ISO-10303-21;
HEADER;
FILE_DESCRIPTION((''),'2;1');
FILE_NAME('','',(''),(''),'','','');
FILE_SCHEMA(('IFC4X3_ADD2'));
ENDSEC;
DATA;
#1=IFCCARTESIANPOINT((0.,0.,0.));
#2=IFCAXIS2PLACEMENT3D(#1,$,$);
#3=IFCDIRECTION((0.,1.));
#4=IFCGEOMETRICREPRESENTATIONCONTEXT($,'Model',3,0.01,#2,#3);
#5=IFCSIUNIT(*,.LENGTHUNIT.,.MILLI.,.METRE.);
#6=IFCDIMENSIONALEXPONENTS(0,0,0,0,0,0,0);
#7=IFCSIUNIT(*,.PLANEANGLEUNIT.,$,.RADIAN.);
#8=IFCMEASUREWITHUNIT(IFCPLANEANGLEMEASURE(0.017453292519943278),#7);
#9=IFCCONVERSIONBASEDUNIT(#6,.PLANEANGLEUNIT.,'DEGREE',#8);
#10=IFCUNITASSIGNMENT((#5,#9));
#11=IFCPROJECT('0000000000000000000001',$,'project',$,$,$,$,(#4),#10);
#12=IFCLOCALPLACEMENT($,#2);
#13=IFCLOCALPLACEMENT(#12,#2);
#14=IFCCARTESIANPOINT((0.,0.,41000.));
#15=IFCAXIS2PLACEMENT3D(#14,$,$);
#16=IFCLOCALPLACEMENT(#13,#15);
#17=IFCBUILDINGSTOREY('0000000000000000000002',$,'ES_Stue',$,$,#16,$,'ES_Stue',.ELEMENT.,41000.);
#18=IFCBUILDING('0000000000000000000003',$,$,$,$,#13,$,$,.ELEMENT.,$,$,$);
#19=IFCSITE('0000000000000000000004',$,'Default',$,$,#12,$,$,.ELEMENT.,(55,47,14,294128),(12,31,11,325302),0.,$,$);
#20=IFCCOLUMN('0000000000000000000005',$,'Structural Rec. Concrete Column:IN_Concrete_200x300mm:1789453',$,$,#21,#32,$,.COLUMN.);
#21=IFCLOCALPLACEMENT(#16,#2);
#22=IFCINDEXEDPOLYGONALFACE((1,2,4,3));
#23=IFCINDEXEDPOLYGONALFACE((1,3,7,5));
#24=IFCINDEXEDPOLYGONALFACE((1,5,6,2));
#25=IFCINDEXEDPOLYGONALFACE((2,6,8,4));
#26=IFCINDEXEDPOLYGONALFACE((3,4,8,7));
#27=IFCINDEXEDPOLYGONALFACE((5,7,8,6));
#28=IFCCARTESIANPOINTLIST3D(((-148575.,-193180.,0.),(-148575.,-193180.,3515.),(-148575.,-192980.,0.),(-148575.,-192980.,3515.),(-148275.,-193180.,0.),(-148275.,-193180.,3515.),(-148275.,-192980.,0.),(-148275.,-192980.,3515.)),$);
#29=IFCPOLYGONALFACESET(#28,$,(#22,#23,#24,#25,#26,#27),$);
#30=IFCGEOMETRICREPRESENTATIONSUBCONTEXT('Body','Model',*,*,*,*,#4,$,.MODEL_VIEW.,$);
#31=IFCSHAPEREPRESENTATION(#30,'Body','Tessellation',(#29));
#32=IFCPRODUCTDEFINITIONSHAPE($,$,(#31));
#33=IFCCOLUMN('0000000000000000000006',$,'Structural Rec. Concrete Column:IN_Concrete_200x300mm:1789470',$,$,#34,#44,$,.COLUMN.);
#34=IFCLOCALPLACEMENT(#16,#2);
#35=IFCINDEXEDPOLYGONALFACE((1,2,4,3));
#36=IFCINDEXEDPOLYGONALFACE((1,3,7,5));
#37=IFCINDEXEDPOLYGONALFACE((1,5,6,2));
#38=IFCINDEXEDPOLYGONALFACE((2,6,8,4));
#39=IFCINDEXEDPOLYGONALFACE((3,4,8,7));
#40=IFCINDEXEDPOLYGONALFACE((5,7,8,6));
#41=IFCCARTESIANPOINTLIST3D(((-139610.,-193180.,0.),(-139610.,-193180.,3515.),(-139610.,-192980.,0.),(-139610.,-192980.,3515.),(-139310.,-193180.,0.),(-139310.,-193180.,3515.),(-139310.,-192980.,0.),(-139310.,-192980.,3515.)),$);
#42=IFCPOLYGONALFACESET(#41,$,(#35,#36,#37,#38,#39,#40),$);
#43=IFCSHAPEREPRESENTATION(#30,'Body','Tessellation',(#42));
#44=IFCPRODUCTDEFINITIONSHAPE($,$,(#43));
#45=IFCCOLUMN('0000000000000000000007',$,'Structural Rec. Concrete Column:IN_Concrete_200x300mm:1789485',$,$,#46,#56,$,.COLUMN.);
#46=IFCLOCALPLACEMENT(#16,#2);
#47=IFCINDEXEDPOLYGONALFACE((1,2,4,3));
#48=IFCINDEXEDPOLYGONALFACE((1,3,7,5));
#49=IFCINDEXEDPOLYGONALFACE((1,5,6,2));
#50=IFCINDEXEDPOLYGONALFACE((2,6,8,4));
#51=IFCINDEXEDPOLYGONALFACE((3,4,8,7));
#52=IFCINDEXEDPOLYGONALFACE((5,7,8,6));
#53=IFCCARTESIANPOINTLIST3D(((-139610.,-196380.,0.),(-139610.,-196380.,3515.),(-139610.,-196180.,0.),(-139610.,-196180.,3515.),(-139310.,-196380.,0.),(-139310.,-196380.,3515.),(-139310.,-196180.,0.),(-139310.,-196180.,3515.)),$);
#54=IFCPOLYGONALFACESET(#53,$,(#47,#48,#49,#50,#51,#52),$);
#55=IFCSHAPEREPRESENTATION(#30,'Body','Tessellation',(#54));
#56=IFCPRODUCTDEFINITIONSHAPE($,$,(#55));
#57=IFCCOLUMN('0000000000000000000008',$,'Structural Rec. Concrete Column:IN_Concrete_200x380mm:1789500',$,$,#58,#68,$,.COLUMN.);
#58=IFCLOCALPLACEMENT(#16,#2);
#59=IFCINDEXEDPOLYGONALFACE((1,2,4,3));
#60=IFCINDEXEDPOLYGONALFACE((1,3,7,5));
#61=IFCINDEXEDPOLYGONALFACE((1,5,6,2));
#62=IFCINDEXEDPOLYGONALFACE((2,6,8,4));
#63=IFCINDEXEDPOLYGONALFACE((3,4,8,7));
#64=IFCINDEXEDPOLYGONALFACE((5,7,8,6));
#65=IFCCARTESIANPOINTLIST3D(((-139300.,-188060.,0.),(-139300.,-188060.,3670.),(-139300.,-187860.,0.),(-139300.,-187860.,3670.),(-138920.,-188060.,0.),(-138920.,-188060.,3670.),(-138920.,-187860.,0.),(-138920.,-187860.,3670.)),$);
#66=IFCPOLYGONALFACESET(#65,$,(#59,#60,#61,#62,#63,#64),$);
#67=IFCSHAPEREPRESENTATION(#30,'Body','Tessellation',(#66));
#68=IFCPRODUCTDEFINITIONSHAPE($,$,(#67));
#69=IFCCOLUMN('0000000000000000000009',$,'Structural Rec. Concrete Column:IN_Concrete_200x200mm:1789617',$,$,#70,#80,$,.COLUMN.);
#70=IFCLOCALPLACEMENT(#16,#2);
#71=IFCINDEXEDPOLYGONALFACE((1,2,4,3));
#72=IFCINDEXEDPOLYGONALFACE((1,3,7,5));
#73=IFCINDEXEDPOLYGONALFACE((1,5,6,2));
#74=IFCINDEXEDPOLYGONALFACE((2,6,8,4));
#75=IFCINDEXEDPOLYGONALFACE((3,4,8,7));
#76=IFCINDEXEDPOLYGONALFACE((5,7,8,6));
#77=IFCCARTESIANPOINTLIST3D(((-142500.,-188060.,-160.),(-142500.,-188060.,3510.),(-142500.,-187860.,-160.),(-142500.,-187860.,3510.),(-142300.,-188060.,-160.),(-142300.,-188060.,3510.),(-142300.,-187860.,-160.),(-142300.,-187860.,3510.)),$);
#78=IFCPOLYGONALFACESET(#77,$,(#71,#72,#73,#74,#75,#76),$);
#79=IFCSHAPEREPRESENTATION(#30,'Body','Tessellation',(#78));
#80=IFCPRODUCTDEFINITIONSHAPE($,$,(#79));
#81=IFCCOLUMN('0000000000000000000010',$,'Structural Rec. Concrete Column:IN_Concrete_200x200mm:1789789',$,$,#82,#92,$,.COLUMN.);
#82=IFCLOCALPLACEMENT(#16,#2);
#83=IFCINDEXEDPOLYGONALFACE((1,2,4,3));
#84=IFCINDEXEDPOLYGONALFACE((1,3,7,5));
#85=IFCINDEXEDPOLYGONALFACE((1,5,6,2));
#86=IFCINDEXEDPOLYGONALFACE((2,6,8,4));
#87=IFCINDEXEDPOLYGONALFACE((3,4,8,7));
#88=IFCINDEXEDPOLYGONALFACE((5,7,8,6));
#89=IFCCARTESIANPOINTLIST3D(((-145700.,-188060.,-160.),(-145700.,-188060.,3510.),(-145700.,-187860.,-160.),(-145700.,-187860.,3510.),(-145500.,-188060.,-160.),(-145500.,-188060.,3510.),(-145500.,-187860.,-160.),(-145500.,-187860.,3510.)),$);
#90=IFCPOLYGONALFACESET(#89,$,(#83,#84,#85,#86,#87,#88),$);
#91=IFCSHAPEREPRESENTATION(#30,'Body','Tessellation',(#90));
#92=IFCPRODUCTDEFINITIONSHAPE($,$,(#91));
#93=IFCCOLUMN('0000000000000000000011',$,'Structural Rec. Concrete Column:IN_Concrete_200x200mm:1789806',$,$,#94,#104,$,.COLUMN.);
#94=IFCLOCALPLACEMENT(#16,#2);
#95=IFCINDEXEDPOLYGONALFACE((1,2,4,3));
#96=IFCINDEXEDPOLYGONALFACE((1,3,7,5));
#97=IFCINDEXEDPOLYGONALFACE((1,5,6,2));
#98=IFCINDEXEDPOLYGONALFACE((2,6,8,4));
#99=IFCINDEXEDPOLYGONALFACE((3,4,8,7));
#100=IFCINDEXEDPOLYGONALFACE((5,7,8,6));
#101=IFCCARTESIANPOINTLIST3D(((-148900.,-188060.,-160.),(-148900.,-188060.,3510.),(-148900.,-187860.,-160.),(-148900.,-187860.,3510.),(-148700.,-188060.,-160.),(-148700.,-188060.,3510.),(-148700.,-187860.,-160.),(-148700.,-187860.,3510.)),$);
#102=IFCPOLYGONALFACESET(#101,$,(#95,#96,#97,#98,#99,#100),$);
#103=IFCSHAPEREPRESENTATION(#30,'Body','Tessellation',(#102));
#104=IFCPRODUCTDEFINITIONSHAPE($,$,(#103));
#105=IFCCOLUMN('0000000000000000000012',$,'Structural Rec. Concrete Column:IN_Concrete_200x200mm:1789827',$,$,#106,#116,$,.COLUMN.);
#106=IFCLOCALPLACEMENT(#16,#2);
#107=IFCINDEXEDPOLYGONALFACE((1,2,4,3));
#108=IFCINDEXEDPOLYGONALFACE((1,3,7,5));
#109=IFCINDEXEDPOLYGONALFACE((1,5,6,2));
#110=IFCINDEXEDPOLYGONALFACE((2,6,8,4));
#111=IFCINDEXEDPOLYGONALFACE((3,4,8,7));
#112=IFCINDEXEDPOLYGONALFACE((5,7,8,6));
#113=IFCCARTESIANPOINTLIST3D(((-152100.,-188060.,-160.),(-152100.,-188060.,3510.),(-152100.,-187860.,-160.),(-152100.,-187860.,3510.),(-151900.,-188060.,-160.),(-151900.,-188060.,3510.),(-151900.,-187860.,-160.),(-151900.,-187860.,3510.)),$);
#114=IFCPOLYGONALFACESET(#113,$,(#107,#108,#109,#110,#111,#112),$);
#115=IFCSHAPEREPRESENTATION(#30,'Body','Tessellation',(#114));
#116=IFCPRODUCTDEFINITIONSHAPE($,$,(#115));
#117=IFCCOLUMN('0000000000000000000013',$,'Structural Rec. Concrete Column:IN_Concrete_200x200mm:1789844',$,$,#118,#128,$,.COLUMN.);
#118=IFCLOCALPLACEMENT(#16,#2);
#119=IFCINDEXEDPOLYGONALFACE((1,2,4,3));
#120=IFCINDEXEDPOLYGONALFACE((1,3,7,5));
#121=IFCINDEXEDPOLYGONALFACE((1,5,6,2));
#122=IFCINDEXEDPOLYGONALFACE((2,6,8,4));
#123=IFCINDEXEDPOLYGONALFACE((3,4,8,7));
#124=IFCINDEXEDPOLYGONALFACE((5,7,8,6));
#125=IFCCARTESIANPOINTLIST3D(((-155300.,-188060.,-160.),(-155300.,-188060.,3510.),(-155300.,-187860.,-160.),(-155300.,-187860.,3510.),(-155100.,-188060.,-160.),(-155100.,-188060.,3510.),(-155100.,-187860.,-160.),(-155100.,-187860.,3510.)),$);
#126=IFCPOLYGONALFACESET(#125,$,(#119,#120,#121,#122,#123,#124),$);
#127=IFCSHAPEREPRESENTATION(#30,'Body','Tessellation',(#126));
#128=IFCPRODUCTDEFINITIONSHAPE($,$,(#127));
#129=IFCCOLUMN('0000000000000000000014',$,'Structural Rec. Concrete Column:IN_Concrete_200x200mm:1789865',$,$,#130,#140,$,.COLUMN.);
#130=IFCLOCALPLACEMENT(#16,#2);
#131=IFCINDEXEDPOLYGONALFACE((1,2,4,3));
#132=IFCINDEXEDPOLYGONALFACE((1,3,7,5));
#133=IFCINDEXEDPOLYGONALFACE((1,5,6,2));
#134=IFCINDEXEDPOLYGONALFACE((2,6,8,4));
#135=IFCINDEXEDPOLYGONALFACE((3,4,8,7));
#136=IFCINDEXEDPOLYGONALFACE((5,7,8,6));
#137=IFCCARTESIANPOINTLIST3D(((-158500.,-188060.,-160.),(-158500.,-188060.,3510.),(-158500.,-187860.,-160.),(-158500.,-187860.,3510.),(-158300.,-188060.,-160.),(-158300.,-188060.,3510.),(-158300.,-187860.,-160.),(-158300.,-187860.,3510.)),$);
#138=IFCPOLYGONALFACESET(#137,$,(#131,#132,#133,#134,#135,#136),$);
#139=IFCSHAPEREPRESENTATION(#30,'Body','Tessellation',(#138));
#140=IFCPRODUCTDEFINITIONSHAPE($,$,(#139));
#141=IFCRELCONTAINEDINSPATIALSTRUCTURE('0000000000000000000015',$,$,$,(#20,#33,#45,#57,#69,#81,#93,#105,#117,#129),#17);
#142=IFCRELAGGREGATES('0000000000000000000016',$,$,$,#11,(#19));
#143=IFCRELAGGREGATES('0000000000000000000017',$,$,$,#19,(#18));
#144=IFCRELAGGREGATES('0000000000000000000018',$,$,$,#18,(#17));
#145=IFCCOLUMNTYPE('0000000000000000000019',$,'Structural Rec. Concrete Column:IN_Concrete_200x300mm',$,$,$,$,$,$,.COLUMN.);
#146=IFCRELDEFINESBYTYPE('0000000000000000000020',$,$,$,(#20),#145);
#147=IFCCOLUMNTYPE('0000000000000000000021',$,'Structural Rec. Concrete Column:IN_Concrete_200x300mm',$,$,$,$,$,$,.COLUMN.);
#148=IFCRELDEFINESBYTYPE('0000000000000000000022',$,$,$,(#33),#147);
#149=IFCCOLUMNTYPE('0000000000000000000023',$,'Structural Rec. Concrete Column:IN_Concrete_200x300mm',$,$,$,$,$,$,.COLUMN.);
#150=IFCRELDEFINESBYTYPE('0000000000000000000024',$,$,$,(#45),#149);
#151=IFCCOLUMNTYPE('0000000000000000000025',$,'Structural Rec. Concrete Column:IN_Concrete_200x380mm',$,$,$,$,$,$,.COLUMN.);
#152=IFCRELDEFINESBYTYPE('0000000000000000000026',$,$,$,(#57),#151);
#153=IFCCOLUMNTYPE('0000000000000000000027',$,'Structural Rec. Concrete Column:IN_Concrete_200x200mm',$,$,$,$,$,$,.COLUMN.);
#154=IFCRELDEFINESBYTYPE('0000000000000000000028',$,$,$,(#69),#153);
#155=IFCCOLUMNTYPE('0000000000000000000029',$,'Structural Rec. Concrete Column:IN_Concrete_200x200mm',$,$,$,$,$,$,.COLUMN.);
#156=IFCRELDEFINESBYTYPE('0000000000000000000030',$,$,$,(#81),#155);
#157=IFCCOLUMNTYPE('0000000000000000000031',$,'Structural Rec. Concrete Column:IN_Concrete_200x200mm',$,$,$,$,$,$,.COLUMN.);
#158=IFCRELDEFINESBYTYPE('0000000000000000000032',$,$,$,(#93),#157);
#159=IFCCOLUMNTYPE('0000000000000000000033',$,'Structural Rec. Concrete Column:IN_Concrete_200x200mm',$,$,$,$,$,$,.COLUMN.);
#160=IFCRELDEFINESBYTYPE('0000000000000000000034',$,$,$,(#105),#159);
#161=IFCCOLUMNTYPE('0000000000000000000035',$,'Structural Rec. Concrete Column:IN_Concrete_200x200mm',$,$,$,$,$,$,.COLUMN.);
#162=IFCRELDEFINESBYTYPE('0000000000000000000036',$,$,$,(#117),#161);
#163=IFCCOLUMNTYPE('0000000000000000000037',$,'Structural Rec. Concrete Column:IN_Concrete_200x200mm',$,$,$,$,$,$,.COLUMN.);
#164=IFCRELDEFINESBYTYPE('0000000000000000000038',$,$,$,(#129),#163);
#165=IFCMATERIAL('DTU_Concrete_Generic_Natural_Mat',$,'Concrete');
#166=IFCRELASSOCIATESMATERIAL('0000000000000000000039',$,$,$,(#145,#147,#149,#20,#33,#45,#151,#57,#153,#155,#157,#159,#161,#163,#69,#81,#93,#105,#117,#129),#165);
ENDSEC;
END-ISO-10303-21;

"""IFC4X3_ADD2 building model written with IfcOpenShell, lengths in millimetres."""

from ifc_helpers import new_model, entity, si_unit, converted_unit, direction, frame, frame_2d, origin, place, context, subcontext, project, spatial, rectangle, extrude, source, transform, mapped, material, material_profile, profile_set, profile_usage, type_object, type_shapes, element, save


model = new_model("IFC4X3_ADD2")

# Units and contexts
model_context = context("Model", 3, precision=0.01, world=origin(), true_north=direction((0.0, 1.0)))
body_context = subcontext(model_context, "Body", "Model", "MODEL_VIEW")
ifc_project = project(units=[si_unit("LENGTHUNIT", "METRE", prefix="MILLI"), converted_unit("PLANEANGLEUNIT", "DEGREE", entity("IfcPlaneAngleMeasure", 0.017453292519943278), si_unit("PLANEANGLEUNIT", "RADIAN"), dimensions=[0, 0, 0, 0, 0, 0, 0])], contexts=[model_context])

# Site, building, storey
site_placement = place(None, origin())
site = spatial("IfcSite", under=ifc_project, at=site_placement, Name="Default", CompositionType="ELEMENT", RefLatitude=(55, 47, 14, 294128), RefLongitude=(12, 31, 11, 325302), RefElevation=0.0)
building_placement = place(site_placement, origin())
building = spatial("IfcBuilding", under=site, at=building_placement, CompositionType="ELEMENT")
storey_placement = place(building_placement, frame((0.0, 0.0, 41000.0)))
storey = spatial("IfcBuildingStorey", under=building, at=storey_placement, Name="ES_Stue", LongName="ES_Stue", CompositionType="ELEMENT", Elevation=41000.0)

# Columns
ifc_material = material(Name="DTU_Concrete_Generic_Natural_Mat", Category="Concrete")
ifc_material_profile_1 = material_profile(ifc_material, rectangle(XDim=200.0, YDim=300.0, at=frame_2d((0.0, 0.0), x_axis=(1.0, 0.0))), Name="IN_Concrete_200x300mm")
ifc_profile_set_1 = profile_set([ifc_material_profile_1], Name="IN_Concrete_200x300mm")
ifc_profile_usage_1 = profile_usage(ifc_profile_set_1)
column_type_1 = type_object("IfcColumnType", Name="Structural Rec. Concrete Column:IN_Concrete_200x300mm", PredefinedType="COLUMN", material=ifc_profile_set_1)
shared_shape_1 = source(origin(), body_context, "Body", "SweptSolid", [
    extrude(rectangle(XDim=200.0, YDim=300.0, at=frame_2d((0.0, 0.0), x_axis=(1.0, 0.0))), frame((-148425.0, -193080.0, 41000.0), z_axis=(0.0, 0.0, 1.0), x_axis=(0.0, -1.0, 0.0)), (0.0, 0.0, 1.0), 3515.0),
])
type_shapes(column_type_1, [shared_shape_1])
column_1_placement = place(storey_placement, frame((0.0, 0.0, -41000.0)))
element("IfcColumn", 1, at=column_1_placement, inside=storey, type_object=column_type_1, material=ifc_profile_usage_1, Name="Structural Rec. Concrete Column:IN_Concrete_200x300mm:1789453", PredefinedType="COLUMN", context=body_context, shape_type="MappedRepresentation", body=[
    mapped(shared_shape_1, transform((0.0, 0.0, 0.0), scale=1.0)),
])
column_type_2 = type_object("IfcColumnType", Name="Structural Rec. Concrete Column:IN_Concrete_200x300mm", PredefinedType="COLUMN", material=ifc_profile_set_1)
shared_shape_2 = source(origin(), body_context, "Body", "SweptSolid", [
    extrude(rectangle(XDim=200.0, YDim=300.0, at=frame_2d((0.0, 0.0), x_axis=(1.0, 0.0))), frame((-139460.0, -193080.0, 41000.0), z_axis=(0.0, 0.0, 1.0), x_axis=(0.0, -1.0, 0.0)), (0.0, 0.0, 1.0), 3515.0),
])
type_shapes(column_type_2, [shared_shape_2])
column_2_placement = place(storey_placement, frame((0.0, 0.0, -41000.0)))
element("IfcColumn", 2, at=column_2_placement, inside=storey, type_object=column_type_2, material=ifc_profile_usage_1, Name="Structural Rec. Concrete Column:IN_Concrete_200x300mm:1789470", PredefinedType="COLUMN", context=body_context, shape_type="MappedRepresentation", body=[
    mapped(shared_shape_2, transform((0.0, 0.0, 0.0), scale=1.0)),
])
column_type_3 = type_object("IfcColumnType", Name="Structural Rec. Concrete Column:IN_Concrete_200x300mm", PredefinedType="COLUMN", material=ifc_profile_set_1)
shared_shape_3 = source(origin(), body_context, "Body", "SweptSolid", [
    extrude(rectangle(XDim=200.0, YDim=300.0, at=frame_2d((0.0, 0.0), x_axis=(1.0, 0.0))), frame((-139460.0, -196280.0, 41000.0), z_axis=(0.0, 0.0, 1.0), x_axis=(0.0, -1.0, 0.0)), (0.0, 0.0, 1.0), 3515.0),
])
type_shapes(column_type_3, [shared_shape_3])
column_3_placement = place(storey_placement, frame((0.0, 0.0, -41000.0)))
element("IfcColumn", 3, at=column_3_placement, inside=storey, type_object=column_type_3, material=ifc_profile_usage_1, Name="Structural Rec. Concrete Column:IN_Concrete_200x300mm:1789485", PredefinedType="COLUMN", context=body_context, shape_type="MappedRepresentation", body=[
    mapped(shared_shape_3, transform((0.0, 0.0, 0.0), scale=1.0)),
])
ifc_material_profile_2 = material_profile(ifc_material, rectangle(XDim=200.0, YDim=380.0, at=frame_2d((0.0, 0.0), x_axis=(1.0, 0.0))), Name="IN_Concrete_200x380mm")
ifc_profile_set_2 = profile_set([ifc_material_profile_2], Name="IN_Concrete_200x380mm")
ifc_profile_usage_2 = profile_usage(ifc_profile_set_2)
column_type_4 = type_object("IfcColumnType", Name="Structural Rec. Concrete Column:IN_Concrete_200x380mm", PredefinedType="COLUMN", material=ifc_profile_set_2)
shared_shape_4 = source(origin(), body_context, "Body", "SweptSolid", [
    extrude(rectangle(XDim=200.0, YDim=380.0, at=frame_2d((0.0, 0.0), x_axis=(1.0, 0.0))), frame((-139110.0, -187960.0, 41000.0), z_axis=(0.0, 0.0, 1.0), x_axis=(0.0, -1.0, 0.0)), (0.0, 0.0, 1.0), 3670.0),
])
type_shapes(column_type_4, [shared_shape_4])
column_4_placement = place(storey_placement, frame((0.0, 0.0, -41000.0)))
element("IfcColumn", 4, at=column_4_placement, inside=storey, type_object=column_type_4, material=ifc_profile_usage_2, Name="Structural Rec. Concrete Column:IN_Concrete_200x380mm:1789500", PredefinedType="COLUMN", context=body_context, shape_type="MappedRepresentation", body=[
    mapped(shared_shape_4, transform((0.0, 0.0, 0.0), scale=1.0)),
])
ifc_material_profile_3 = material_profile(ifc_material, rectangle(XDim=200.0, YDim=200.0, at=frame_2d((0.0, 0.0), x_axis=(1.0, 0.0))), Name="IN_Concrete_200x200mm")
ifc_profile_set_3 = profile_set([ifc_material_profile_3], Name="IN_Concrete_200x200mm")
ifc_profile_usage_3 = profile_usage(ifc_profile_set_3)
column_type_5 = type_object("IfcColumnType", Name="Structural Rec. Concrete Column:IN_Concrete_200x200mm", PredefinedType="COLUMN", material=ifc_profile_set_3)
shared_shape_5 = source(origin(), body_context, "Body", "SweptSolid", [
    extrude(rectangle(XDim=200.0, YDim=200.0, at=frame_2d((0.0, 0.0), x_axis=(1.0, 0.0))), frame((-142400.0, -187960.0, 40840.0), z_axis=(0.0, 0.0, 1.0), x_axis=(-1.0, 0.0, 0.0)), (0.0, 0.0, 1.0), 3670.0),
])
type_shapes(column_type_5, [shared_shape_5])
column_5_placement = place(storey_placement, frame((0.0, 0.0, -41000.0)))
element("IfcColumn", 5, at=column_5_placement, inside=storey, type_object=column_type_5, material=ifc_profile_usage_3, Name="Structural Rec. Concrete Column:IN_Concrete_200x200mm:1789617", PredefinedType="COLUMN", context=body_context, shape_type="MappedRepresentation", body=[
    mapped(shared_shape_5, transform((0.0, 0.0, 0.0), scale=1.0)),
])
column_type_6 = type_object("IfcColumnType", Name="Structural Rec. Concrete Column:IN_Concrete_200x200mm", PredefinedType="COLUMN", material=ifc_profile_set_3)
shared_shape_6 = source(origin(), body_context, "Body", "SweptSolid", [
    extrude(rectangle(XDim=200.0, YDim=200.0, at=frame_2d((0.0, 0.0), x_axis=(1.0, 0.0))), frame((-145600.0, -187960.0, 40840.0), z_axis=(0.0, 0.0, 1.0), x_axis=(-1.0, 0.0, 0.0)), (0.0, 0.0, 1.0), 3670.0),
])
type_shapes(column_type_6, [shared_shape_6])
column_6_placement = place(storey_placement, frame((0.0, 0.0, -41000.0)))
element("IfcColumn", 6, at=column_6_placement, inside=storey, type_object=column_type_6, material=ifc_profile_usage_3, Name="Structural Rec. Concrete Column:IN_Concrete_200x200mm:1789789", PredefinedType="COLUMN", context=body_context, shape_type="MappedRepresentation", body=[
    mapped(shared_shape_6, transform((0.0, 0.0, 0.0), scale=1.0)),
])
column_type_7 = type_object("IfcColumnType", Name="Structural Rec. Concrete Column:IN_Concrete_200x200mm", PredefinedType="COLUMN", material=ifc_profile_set_3)
shared_shape_7 = source(origin(), body_context, "Body", "SweptSolid", [
    extrude(rectangle(XDim=200.0, YDim=200.0, at=frame_2d((0.0, 0.0), x_axis=(1.0, 0.0))), frame((-148800.0, -187960.0, 40840.0), z_axis=(0.0, 0.0, 1.0), x_axis=(-1.0, 0.0, 0.0)), (0.0, 0.0, 1.0), 3670.0),
])
type_shapes(column_type_7, [shared_shape_7])
column_7_placement = place(storey_placement, frame((0.0, 0.0, -41000.0)))
element("IfcColumn", 7, at=column_7_placement, inside=storey, type_object=column_type_7, material=ifc_profile_usage_3, Name="Structural Rec. Concrete Column:IN_Concrete_200x200mm:1789806", PredefinedType="COLUMN", context=body_context, shape_type="MappedRepresentation", body=[
    mapped(shared_shape_7, transform((0.0, 0.0, 0.0), scale=1.0)),
])
column_type_8 = type_object("IfcColumnType", Name="Structural Rec. Concrete Column:IN_Concrete_200x200mm", PredefinedType="COLUMN", material=ifc_profile_set_3)
shared_shape_8 = source(origin(), body_context, "Body", "SweptSolid", [
    extrude(rectangle(XDim=200.0, YDim=200.0, at=frame_2d((0.0, 0.0), x_axis=(1.0, 0.0))), frame((-152000.0, -187960.0, 40840.0), z_axis=(0.0, 0.0, 1.0), x_axis=(-1.0, 0.0, 0.0)), (0.0, 0.0, 1.0), 3670.0),
])
type_shapes(column_type_8, [shared_shape_8])
column_8_placement = place(storey_placement, frame((0.0, 0.0, -41000.0)))
element("IfcColumn", 8, at=column_8_placement, inside=storey, type_object=column_type_8, material=ifc_profile_usage_3, Name="Structural Rec. Concrete Column:IN_Concrete_200x200mm:1789827", PredefinedType="COLUMN", context=body_context, shape_type="MappedRepresentation", body=[
    mapped(shared_shape_8, transform((0.0, 0.0, 0.0), scale=1.0)),
])
column_type_9 = type_object("IfcColumnType", Name="Structural Rec. Concrete Column:IN_Concrete_200x200mm", PredefinedType="COLUMN", material=ifc_profile_set_3)
shared_shape_9 = source(origin(), body_context, "Body", "SweptSolid", [
    extrude(rectangle(XDim=200.0, YDim=200.0, at=frame_2d((0.0, 0.0), x_axis=(1.0, 0.0))), frame((-155200.0, -187960.0, 40840.0), z_axis=(0.0, 0.0, 1.0), x_axis=(-1.0, 0.0, 0.0)), (0.0, 0.0, 1.0), 3670.0),
])
type_shapes(column_type_9, [shared_shape_9])
column_9_placement = place(storey_placement, frame((0.0, 0.0, -41000.0)))
element("IfcColumn", 9, at=column_9_placement, inside=storey, type_object=column_type_9, material=ifc_profile_usage_3, Name="Structural Rec. Concrete Column:IN_Concrete_200x200mm:1789844", PredefinedType="COLUMN", context=body_context, shape_type="MappedRepresentation", body=[
    mapped(shared_shape_9, transform((0.0, 0.0, 0.0), scale=1.0)),
])
column_type_10 = type_object("IfcColumnType", Name="Structural Rec. Concrete Column:IN_Concrete_200x200mm", PredefinedType="COLUMN", material=ifc_profile_set_3)
shared_shape_10 = source(origin(), body_context, "Body", "SweptSolid", [
    extrude(rectangle(XDim=200.0, YDim=200.0, at=frame_2d((0.0, 0.0), x_axis=(1.0, 0.0))), frame((-158400.0, -187960.0, 40840.0), z_axis=(0.0, 0.0, 1.0), x_axis=(-1.0, 0.0, 0.0)), (0.0, 0.0, 1.0), 3670.0),
])
type_shapes(column_type_10, [shared_shape_10])
column_10_placement = place(storey_placement, frame((0.0, 0.0, -41000.0)))
element("IfcColumn", 10, at=column_10_placement, inside=storey, type_object=column_type_10, material=ifc_profile_usage_3, Name="Structural Rec. Concrete Column:IN_Concrete_200x200mm:1789865", PredefinedType="COLUMN", context=body_context, shape_type="MappedRepresentation", body=[
    mapped(shared_shape_10, transform((0.0, 0.0, 0.0), scale=1.0)),
])

save(model, "model.ifc")
